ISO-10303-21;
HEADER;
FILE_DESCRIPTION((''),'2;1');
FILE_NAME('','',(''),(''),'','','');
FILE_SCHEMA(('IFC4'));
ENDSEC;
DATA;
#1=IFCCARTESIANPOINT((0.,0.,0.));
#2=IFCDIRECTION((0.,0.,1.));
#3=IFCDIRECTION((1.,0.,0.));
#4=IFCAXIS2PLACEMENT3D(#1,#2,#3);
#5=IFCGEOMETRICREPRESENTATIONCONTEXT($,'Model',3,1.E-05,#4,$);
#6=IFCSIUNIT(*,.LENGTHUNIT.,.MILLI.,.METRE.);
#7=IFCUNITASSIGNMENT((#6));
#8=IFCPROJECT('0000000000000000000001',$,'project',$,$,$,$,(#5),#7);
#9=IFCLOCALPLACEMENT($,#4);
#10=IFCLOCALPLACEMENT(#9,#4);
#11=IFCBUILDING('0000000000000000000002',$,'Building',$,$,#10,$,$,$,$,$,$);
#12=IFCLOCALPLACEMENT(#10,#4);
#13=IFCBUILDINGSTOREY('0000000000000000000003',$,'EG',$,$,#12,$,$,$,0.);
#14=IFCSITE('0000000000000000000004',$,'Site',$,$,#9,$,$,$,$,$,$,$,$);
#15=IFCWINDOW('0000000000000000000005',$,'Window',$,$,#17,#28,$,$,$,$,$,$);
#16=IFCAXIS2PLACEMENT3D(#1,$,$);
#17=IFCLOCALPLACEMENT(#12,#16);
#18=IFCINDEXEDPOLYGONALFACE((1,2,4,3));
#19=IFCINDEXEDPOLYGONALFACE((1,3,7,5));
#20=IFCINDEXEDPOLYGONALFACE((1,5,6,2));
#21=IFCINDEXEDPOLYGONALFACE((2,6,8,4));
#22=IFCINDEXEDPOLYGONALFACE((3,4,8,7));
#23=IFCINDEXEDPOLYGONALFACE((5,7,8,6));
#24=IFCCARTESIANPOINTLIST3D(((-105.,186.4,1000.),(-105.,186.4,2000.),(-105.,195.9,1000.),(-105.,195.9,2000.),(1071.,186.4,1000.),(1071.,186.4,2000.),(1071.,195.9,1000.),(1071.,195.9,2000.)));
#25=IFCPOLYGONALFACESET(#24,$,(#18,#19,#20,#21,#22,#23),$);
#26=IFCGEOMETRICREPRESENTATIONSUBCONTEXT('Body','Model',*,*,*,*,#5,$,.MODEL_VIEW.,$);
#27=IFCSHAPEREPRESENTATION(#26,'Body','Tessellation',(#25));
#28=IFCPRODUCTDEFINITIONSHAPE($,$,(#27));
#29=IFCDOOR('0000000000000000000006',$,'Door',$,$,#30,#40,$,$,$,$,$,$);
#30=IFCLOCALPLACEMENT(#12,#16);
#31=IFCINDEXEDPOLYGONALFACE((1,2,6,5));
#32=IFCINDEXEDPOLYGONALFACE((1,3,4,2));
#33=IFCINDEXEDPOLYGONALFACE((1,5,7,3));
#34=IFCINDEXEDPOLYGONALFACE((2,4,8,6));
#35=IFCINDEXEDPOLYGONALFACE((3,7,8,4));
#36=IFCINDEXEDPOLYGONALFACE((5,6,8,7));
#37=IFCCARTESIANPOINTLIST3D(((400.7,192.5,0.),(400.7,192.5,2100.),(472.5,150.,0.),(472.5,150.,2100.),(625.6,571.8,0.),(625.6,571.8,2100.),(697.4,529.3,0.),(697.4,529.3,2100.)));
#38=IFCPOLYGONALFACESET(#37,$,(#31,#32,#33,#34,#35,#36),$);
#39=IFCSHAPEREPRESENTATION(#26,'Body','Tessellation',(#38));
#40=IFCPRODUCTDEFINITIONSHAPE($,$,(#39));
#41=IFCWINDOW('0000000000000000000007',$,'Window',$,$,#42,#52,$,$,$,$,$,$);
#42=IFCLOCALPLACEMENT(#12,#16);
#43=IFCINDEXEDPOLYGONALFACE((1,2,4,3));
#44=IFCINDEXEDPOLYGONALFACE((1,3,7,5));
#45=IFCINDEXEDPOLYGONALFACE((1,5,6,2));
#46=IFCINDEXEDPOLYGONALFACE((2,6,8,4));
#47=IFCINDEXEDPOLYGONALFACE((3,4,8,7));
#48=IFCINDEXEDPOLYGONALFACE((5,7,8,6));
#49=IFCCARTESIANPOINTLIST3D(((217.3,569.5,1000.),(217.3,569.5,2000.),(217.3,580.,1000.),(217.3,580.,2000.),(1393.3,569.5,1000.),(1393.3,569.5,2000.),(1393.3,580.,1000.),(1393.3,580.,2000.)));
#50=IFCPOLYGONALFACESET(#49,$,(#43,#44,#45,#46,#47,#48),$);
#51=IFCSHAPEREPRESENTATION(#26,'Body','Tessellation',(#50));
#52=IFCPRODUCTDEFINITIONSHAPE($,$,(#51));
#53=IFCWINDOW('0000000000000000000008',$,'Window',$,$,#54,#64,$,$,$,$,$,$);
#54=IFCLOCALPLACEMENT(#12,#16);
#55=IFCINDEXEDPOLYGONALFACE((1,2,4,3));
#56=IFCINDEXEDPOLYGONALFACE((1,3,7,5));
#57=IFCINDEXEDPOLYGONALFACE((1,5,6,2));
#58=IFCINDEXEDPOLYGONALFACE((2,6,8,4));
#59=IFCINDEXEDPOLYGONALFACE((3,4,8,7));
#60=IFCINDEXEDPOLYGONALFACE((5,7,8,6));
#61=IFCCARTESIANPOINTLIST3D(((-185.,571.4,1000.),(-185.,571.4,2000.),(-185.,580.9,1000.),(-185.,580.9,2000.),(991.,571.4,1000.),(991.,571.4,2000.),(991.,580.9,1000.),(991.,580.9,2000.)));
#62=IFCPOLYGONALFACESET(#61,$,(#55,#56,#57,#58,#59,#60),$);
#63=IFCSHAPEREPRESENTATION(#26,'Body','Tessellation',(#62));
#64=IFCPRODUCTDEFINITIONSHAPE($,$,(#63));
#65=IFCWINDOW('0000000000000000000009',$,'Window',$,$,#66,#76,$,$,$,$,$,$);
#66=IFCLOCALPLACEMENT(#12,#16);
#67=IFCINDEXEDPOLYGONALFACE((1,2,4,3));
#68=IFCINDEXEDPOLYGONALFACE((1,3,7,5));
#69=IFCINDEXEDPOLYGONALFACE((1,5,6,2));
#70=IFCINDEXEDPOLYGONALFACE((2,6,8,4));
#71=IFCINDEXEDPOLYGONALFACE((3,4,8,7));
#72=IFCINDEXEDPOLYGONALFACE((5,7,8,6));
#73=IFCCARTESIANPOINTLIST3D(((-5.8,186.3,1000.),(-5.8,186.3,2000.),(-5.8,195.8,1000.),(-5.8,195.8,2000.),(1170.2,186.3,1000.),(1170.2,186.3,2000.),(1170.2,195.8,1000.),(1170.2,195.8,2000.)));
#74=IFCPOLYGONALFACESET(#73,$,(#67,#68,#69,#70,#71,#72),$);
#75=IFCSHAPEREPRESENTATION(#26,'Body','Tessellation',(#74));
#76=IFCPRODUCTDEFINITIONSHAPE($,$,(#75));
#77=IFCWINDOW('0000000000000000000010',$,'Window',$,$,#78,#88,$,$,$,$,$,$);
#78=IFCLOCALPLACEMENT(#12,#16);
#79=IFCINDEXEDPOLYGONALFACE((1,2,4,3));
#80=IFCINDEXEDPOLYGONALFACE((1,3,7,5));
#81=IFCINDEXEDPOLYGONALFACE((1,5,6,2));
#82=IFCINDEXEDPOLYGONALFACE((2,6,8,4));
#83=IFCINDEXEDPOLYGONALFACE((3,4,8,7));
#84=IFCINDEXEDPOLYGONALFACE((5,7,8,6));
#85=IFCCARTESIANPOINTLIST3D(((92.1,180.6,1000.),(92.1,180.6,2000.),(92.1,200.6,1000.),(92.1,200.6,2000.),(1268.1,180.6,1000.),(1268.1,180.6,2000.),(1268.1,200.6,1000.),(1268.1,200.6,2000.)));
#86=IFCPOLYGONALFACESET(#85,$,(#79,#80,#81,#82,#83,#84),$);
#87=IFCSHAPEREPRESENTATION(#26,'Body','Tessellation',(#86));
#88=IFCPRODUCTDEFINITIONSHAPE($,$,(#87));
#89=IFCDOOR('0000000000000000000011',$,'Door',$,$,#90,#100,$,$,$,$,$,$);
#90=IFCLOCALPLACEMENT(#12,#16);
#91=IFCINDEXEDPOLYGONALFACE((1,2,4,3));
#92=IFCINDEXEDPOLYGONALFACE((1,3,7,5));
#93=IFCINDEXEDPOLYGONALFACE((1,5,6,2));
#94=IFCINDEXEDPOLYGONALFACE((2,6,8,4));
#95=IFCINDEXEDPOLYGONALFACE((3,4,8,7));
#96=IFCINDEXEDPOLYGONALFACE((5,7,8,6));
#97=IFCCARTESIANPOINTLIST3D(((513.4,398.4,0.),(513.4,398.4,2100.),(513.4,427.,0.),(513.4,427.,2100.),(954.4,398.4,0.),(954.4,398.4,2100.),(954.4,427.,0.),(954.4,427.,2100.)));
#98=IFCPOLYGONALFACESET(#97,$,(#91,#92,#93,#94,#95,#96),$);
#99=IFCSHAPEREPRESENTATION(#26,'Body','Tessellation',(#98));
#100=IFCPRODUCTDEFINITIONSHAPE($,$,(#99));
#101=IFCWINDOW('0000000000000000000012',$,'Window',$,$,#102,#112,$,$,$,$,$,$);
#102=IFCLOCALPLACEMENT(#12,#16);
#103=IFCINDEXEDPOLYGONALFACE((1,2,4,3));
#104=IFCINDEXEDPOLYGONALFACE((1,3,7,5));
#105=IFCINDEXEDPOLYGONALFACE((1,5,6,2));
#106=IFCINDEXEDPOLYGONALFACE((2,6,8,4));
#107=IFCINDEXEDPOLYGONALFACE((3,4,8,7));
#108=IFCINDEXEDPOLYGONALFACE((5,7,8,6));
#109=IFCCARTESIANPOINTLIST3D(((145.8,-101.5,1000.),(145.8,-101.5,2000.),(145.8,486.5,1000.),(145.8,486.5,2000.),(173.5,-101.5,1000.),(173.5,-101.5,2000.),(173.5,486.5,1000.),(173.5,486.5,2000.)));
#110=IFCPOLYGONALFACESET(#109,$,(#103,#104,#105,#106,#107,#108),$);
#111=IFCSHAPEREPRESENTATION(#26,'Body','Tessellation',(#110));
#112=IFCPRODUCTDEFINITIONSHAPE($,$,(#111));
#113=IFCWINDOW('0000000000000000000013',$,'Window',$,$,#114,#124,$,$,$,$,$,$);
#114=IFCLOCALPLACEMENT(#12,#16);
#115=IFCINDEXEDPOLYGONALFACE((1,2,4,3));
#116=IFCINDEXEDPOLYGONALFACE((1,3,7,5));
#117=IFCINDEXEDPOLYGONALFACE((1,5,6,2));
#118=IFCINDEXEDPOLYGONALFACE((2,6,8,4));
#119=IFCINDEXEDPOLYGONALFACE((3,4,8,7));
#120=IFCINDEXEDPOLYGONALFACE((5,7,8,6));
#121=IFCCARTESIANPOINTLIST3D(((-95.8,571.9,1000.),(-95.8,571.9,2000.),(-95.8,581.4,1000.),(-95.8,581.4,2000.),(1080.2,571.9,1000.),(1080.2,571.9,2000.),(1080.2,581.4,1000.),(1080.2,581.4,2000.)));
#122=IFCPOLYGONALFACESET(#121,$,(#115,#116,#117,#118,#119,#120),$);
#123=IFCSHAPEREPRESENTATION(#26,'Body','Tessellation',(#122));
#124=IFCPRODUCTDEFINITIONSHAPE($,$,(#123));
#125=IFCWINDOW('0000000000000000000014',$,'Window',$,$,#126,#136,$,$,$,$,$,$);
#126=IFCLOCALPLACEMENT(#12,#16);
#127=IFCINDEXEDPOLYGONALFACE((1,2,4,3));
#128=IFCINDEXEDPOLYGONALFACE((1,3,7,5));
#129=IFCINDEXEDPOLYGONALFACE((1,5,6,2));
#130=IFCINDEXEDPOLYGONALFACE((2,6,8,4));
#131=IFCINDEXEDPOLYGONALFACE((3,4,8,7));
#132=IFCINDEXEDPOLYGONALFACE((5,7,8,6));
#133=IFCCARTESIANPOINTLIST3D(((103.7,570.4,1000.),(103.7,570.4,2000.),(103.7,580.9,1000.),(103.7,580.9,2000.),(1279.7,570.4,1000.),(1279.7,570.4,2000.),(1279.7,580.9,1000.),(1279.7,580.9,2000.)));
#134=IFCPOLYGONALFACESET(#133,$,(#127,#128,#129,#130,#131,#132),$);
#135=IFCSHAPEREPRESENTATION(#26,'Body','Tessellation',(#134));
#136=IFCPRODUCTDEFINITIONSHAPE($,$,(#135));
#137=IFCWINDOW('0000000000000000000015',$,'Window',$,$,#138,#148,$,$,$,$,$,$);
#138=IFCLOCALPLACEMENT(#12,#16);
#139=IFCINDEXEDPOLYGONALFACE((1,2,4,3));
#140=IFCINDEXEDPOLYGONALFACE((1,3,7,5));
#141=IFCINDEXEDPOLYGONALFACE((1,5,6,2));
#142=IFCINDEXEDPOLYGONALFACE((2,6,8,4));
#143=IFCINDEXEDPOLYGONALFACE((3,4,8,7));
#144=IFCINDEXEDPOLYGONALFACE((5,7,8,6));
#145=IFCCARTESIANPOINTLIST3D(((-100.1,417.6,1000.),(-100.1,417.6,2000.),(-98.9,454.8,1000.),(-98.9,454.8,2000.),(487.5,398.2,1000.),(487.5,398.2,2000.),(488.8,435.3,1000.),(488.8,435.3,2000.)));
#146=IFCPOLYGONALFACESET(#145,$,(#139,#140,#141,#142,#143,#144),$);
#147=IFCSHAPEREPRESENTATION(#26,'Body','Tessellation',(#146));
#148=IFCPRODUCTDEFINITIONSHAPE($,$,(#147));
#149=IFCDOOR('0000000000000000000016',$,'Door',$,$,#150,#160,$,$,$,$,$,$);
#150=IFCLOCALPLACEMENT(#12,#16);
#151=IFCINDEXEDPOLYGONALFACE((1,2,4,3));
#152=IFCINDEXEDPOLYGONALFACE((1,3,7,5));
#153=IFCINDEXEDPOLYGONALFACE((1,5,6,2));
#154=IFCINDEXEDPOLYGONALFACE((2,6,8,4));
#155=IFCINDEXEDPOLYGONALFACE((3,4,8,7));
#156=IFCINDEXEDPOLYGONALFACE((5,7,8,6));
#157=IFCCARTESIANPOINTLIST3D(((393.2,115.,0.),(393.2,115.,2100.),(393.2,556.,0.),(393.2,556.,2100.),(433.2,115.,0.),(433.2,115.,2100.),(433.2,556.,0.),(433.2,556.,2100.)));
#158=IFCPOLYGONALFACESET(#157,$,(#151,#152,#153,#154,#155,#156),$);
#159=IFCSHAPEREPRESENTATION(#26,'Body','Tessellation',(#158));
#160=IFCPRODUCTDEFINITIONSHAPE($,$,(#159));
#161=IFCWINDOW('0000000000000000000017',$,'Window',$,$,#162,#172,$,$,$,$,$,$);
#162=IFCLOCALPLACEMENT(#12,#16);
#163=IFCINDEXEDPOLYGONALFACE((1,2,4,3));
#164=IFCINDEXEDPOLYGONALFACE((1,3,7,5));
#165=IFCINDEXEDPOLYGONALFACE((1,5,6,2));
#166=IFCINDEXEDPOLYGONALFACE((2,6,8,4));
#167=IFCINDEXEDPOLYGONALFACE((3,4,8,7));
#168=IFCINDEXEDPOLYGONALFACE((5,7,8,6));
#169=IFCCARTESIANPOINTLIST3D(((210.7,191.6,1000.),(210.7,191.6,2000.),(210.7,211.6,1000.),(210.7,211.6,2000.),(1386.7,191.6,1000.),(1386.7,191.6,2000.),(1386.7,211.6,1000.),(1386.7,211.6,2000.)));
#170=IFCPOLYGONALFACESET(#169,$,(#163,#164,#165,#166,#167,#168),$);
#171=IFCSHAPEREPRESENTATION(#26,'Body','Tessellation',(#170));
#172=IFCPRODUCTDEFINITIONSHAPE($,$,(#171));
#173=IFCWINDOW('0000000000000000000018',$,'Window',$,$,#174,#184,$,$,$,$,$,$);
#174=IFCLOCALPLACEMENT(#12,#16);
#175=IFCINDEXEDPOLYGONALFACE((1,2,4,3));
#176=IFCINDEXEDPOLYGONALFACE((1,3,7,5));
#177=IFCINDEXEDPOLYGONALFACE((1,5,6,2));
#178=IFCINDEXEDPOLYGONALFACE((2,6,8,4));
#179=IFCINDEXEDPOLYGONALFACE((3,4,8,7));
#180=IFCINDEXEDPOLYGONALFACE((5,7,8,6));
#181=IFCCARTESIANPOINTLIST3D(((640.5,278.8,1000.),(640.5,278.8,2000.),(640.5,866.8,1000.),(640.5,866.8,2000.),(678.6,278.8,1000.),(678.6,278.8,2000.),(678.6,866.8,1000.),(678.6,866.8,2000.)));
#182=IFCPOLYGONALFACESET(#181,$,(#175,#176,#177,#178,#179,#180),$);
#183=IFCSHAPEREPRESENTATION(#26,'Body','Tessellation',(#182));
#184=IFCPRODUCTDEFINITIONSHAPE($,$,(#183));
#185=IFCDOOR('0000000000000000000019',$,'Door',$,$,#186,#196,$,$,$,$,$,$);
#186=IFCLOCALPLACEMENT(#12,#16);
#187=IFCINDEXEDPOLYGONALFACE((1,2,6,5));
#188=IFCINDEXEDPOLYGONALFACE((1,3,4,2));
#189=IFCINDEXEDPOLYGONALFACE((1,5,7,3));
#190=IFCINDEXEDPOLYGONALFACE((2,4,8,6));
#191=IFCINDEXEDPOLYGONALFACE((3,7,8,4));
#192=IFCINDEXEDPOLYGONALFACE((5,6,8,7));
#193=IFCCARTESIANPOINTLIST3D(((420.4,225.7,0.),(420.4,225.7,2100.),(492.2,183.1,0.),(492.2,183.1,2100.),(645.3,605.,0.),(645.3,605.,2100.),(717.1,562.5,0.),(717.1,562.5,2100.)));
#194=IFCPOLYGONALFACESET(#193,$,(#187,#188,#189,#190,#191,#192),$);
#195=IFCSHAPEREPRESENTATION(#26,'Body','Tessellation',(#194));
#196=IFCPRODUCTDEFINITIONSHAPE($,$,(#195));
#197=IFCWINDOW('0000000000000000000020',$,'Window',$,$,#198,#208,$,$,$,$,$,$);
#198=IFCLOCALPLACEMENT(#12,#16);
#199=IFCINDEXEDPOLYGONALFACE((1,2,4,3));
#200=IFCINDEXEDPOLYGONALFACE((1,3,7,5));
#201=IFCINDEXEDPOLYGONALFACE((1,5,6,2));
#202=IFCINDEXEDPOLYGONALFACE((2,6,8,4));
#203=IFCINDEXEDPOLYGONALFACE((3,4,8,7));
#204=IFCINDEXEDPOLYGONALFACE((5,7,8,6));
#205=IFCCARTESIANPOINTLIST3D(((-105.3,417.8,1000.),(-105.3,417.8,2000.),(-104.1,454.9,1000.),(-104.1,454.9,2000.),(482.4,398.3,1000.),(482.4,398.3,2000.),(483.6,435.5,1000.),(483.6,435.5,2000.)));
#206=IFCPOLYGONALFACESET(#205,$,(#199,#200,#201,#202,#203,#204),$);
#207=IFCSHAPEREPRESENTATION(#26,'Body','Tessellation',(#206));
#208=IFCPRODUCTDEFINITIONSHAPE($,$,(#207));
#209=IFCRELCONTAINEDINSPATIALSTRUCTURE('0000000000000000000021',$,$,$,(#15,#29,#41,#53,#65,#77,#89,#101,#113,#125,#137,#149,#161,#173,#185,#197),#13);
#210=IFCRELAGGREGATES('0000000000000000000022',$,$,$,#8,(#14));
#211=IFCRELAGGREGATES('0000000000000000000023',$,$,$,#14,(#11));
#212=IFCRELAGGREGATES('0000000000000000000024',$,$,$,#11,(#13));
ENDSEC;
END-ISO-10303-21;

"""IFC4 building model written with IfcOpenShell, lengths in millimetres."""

from ifc_helpers import new_model, si_unit, frame, origin_with_axes, place, context, subcontext, project, spatial, rectangle, extrude, element, save


model = new_model("IFC4")

# Units and contexts
model_context = context("Model", 3, precision=1e-05, world=origin_with_axes())
body_context = subcontext(model_context, "Body", "Model", "MODEL_VIEW")
ifc_project = project(units=[si_unit("LENGTHUNIT", "METRE", prefix="MILLI")], contexts=[model_context])

# Site, building, storey
site_placement = place(None, origin_with_axes())
site = spatial("IfcSite", under=ifc_project, at=site_placement, Name="Site")
building_placement = place(site_placement, origin_with_axes())
building = spatial("IfcBuilding", under=site, at=building_placement, Name="Building")
storey_placement = place(building_placement, origin_with_axes())
storey = spatial("IfcBuildingStorey", under=building, at=storey_placement, Name="EG", Elevation=0.0)

# Window
window_1_placement = place(storey_placement, origin_with_axes())
element("IfcWindow", 1, at=window_1_placement, inside=storey, Name="Window", context=body_context, shape_type="SweptSolid", body=[
    extrude(rectangle(XDim=1176.0, YDim=9.5), frame((483.0, 191.1, 1000.0), z_axis=(0.0, 0.0, 1.0), x_axis=(1.0, 0.0, 0.0)), (0.0, 0.0, 1.0), 1000.0),
])

# Door
door_1_placement = place(storey_placement, origin_with_axes())
element("IfcDoor", 2, at=door_1_placement, inside=storey, Name="Door", context=body_context, shape_type="SweptSolid", body=[
    extrude(rectangle(XDim=441.0, YDim=83.5), frame((549.1, 360.9, 0.0), z_axis=(0.0, 0.0, 1.0), x_axis=(0.510011, 0.860168, 0.0)), (0.0, 0.0, 1.0), 2100.0),
])

# Windows
window_2_placement = place(storey_placement, origin_with_axes())
element("IfcWindow", 3, at=window_2_placement, inside=storey, Name="Window", context=body_context, shape_type="SweptSolid", body=[
    extrude(rectangle(XDim=1176.0, YDim=10.5), frame((805.3, 574.7, 1000.0), z_axis=(0.0, 0.0, 1.0), x_axis=(1.0, 0.0, 0.0)), (0.0, 0.0, 1.0), 1000.0),
])
window_3_placement = place(storey_placement, origin_with_axes())
element("IfcWindow", 4, at=window_3_placement, inside=storey, Name="Window", context=body_context, shape_type="SweptSolid", body=[
    extrude(rectangle(XDim=1176.0, YDim=9.5), frame((403.0, 576.1, 1000.0), z_axis=(0.0, 0.0, 1.0), x_axis=(1.0, 0.0, 0.0)), (0.0, 0.0, 1.0), 1000.0),
])
window_4_placement = place(storey_placement, origin_with_axes())
element("IfcWindow", 5, at=window_4_placement, inside=storey, Name="Window", context=body_context, shape_type="SweptSolid", body=[
    extrude(rectangle(XDim=1176.0, YDim=9.5), frame((582.2, 191.1, 1000.0), z_axis=(0.0, 0.0, 1.0), x_axis=(1.0, 0.0, 0.0)), (0.0, 0.0, 1.0), 1000.0),
])
window_5_placement = place(storey_placement, origin_with_axes())
element("IfcWindow", 6, at=window_5_placement, inside=storey, Name="Window", context=body_context, shape_type="SweptSolid", body=[
    extrude(rectangle(XDim=1176.0, YDim=20.0), frame((680.1, 190.6, 1000.0), z_axis=(0.0, 0.0, 1.0), x_axis=(1.0, 0.0, 0.0)), (0.0, 0.0, 1.0), 1000.0),
])

# Door
door_2_placement = place(storey_placement, origin_with_axes())
element("IfcDoor", 7, at=door_2_placement, inside=storey, Name="Door", context=body_context, shape_type="SweptSolid", body=[
    extrude(rectangle(XDim=441.0, YDim=28.6), frame((733.9, 412.7, 0.0), z_axis=(0.0, 0.0, 1.0), x_axis=(1.0, 0.0, 0.0)), (0.0, 0.0, 1.0), 2100.0),
])

# Windows
window_6_placement = place(storey_placement, origin_with_axes())
element("IfcWindow", 8, at=window_6_placement, inside=storey, Name="Window", context=body_context, shape_type="SweptSolid", body=[
    extrude(rectangle(XDim=588.0, YDim=27.6), frame((159.6, 192.5, 1000.0), z_axis=(0.0, 0.0, 1.0), x_axis=(0.0, -1.0, 0.0)), (0.0, 0.0, 1.0), 1000.0),
])
window_7_placement = place(storey_placement, origin_with_axes())
element("IfcWindow", 9, at=window_7_placement, inside=storey, Name="Window", context=body_context, shape_type="SweptSolid", body=[
    extrude(rectangle(XDim=1176.0, YDim=9.5), frame((492.2, 576.6, 1000.0), z_axis=(0.0, 0.0, 1.0), x_axis=(1.0, 0.0, 0.0)), (0.0, 0.0, 1.0), 1000.0),
])
window_8_placement = place(storey_placement, origin_with_axes())
element("IfcWindow", 10, at=window_8_placement, inside=storey, Name="Window", context=body_context, shape_type="SweptSolid", body=[
    extrude(rectangle(XDim=1176.0, YDim=10.5), frame((691.7, 575.6, 1000.0), z_axis=(0.0, 0.0, 1.0), x_axis=(1.0, 0.0, 0.0)), (0.0, 0.0, 1.0), 1000.0),
])
window_9_placement = place(storey_placement, origin_with_axes())
element("IfcWindow", 11, at=window_9_placement, inside=storey, Name="Window", context=body_context, shape_type="SweptSolid", body=[
    extrude(rectangle(XDim=588.0, YDim=37.2), frame((194.3, 426.5, 1000.0), z_axis=(0.0, 0.0, 1.0), x_axis=(-0.999454, 0.03304, 0.0)), (0.0, 0.0, 1.0), 1000.0),
])

# Door
door_3_placement = place(storey_placement, origin_with_axes())
element("IfcDoor", 12, at=door_3_placement, inside=storey, Name="Door", context=body_context, shape_type="SweptSolid", body=[
    extrude(rectangle(XDim=441.0, YDim=40.0), frame((413.2, 335.5, 0.0), z_axis=(0.0, 0.0, 1.0), x_axis=(0.0, 1.0, 0.0)), (0.0, 0.0, 1.0), 2100.0),
])

# Windows
window_10_placement = place(storey_placement, origin_with_axes())
element("IfcWindow", 13, at=window_10_placement, inside=storey, Name="Window", context=body_context, shape_type="SweptSolid", body=[
    extrude(rectangle(XDim=1176.0, YDim=20.0), frame((798.7, 201.6, 1000.0), z_axis=(0.0, 0.0, 1.0), x_axis=(1.0, 0.0, 0.0)), (0.0, 0.0, 1.0), 1000.0),
])
window_11_placement = place(storey_placement, origin_with_axes())
element("IfcWindow", 14, at=window_11_placement, inside=storey, Name="Window", context=body_context, shape_type="SweptSolid", body=[
    extrude(rectangle(XDim=588.0, YDim=38.1), frame((659.6, 572.8, 1000.0), z_axis=(0.0, 0.0, 1.0), x_axis=(0.0, 1.0, 0.0)), (0.0, 0.0, 1.0), 1000.0),
])

# Door
door_4_placement = place(storey_placement, origin_with_axes())
element("IfcDoor", 15, at=door_4_placement, inside=storey, Name="Door", context=body_context, shape_type="SweptSolid", body=[
    extrude(rectangle(XDim=441.0, YDim=83.5), frame((568.7, 394.1, 0.0), z_axis=(0.0, 0.0, 1.0), x_axis=(0.510011, 0.860168, 0.0)), (0.0, 0.0, 1.0), 2100.0),
])

# Window
window_12_placement = place(storey_placement, origin_with_axes())
element("IfcWindow", 16, at=window_12_placement, inside=storey, Name="Window", context=body_context, shape_type="SweptSolid", body=[
    extrude(rectangle(XDim=588.0, YDim=37.2), frame((189.2, 426.6, 1000.0), z_axis=(0.0, 0.0, 1.0), x_axis=(-0.999454, 0.03304, 0.0)), (0.0, 0.0, 1.0), 1000.0),
])

save(model, "model.ifc")
